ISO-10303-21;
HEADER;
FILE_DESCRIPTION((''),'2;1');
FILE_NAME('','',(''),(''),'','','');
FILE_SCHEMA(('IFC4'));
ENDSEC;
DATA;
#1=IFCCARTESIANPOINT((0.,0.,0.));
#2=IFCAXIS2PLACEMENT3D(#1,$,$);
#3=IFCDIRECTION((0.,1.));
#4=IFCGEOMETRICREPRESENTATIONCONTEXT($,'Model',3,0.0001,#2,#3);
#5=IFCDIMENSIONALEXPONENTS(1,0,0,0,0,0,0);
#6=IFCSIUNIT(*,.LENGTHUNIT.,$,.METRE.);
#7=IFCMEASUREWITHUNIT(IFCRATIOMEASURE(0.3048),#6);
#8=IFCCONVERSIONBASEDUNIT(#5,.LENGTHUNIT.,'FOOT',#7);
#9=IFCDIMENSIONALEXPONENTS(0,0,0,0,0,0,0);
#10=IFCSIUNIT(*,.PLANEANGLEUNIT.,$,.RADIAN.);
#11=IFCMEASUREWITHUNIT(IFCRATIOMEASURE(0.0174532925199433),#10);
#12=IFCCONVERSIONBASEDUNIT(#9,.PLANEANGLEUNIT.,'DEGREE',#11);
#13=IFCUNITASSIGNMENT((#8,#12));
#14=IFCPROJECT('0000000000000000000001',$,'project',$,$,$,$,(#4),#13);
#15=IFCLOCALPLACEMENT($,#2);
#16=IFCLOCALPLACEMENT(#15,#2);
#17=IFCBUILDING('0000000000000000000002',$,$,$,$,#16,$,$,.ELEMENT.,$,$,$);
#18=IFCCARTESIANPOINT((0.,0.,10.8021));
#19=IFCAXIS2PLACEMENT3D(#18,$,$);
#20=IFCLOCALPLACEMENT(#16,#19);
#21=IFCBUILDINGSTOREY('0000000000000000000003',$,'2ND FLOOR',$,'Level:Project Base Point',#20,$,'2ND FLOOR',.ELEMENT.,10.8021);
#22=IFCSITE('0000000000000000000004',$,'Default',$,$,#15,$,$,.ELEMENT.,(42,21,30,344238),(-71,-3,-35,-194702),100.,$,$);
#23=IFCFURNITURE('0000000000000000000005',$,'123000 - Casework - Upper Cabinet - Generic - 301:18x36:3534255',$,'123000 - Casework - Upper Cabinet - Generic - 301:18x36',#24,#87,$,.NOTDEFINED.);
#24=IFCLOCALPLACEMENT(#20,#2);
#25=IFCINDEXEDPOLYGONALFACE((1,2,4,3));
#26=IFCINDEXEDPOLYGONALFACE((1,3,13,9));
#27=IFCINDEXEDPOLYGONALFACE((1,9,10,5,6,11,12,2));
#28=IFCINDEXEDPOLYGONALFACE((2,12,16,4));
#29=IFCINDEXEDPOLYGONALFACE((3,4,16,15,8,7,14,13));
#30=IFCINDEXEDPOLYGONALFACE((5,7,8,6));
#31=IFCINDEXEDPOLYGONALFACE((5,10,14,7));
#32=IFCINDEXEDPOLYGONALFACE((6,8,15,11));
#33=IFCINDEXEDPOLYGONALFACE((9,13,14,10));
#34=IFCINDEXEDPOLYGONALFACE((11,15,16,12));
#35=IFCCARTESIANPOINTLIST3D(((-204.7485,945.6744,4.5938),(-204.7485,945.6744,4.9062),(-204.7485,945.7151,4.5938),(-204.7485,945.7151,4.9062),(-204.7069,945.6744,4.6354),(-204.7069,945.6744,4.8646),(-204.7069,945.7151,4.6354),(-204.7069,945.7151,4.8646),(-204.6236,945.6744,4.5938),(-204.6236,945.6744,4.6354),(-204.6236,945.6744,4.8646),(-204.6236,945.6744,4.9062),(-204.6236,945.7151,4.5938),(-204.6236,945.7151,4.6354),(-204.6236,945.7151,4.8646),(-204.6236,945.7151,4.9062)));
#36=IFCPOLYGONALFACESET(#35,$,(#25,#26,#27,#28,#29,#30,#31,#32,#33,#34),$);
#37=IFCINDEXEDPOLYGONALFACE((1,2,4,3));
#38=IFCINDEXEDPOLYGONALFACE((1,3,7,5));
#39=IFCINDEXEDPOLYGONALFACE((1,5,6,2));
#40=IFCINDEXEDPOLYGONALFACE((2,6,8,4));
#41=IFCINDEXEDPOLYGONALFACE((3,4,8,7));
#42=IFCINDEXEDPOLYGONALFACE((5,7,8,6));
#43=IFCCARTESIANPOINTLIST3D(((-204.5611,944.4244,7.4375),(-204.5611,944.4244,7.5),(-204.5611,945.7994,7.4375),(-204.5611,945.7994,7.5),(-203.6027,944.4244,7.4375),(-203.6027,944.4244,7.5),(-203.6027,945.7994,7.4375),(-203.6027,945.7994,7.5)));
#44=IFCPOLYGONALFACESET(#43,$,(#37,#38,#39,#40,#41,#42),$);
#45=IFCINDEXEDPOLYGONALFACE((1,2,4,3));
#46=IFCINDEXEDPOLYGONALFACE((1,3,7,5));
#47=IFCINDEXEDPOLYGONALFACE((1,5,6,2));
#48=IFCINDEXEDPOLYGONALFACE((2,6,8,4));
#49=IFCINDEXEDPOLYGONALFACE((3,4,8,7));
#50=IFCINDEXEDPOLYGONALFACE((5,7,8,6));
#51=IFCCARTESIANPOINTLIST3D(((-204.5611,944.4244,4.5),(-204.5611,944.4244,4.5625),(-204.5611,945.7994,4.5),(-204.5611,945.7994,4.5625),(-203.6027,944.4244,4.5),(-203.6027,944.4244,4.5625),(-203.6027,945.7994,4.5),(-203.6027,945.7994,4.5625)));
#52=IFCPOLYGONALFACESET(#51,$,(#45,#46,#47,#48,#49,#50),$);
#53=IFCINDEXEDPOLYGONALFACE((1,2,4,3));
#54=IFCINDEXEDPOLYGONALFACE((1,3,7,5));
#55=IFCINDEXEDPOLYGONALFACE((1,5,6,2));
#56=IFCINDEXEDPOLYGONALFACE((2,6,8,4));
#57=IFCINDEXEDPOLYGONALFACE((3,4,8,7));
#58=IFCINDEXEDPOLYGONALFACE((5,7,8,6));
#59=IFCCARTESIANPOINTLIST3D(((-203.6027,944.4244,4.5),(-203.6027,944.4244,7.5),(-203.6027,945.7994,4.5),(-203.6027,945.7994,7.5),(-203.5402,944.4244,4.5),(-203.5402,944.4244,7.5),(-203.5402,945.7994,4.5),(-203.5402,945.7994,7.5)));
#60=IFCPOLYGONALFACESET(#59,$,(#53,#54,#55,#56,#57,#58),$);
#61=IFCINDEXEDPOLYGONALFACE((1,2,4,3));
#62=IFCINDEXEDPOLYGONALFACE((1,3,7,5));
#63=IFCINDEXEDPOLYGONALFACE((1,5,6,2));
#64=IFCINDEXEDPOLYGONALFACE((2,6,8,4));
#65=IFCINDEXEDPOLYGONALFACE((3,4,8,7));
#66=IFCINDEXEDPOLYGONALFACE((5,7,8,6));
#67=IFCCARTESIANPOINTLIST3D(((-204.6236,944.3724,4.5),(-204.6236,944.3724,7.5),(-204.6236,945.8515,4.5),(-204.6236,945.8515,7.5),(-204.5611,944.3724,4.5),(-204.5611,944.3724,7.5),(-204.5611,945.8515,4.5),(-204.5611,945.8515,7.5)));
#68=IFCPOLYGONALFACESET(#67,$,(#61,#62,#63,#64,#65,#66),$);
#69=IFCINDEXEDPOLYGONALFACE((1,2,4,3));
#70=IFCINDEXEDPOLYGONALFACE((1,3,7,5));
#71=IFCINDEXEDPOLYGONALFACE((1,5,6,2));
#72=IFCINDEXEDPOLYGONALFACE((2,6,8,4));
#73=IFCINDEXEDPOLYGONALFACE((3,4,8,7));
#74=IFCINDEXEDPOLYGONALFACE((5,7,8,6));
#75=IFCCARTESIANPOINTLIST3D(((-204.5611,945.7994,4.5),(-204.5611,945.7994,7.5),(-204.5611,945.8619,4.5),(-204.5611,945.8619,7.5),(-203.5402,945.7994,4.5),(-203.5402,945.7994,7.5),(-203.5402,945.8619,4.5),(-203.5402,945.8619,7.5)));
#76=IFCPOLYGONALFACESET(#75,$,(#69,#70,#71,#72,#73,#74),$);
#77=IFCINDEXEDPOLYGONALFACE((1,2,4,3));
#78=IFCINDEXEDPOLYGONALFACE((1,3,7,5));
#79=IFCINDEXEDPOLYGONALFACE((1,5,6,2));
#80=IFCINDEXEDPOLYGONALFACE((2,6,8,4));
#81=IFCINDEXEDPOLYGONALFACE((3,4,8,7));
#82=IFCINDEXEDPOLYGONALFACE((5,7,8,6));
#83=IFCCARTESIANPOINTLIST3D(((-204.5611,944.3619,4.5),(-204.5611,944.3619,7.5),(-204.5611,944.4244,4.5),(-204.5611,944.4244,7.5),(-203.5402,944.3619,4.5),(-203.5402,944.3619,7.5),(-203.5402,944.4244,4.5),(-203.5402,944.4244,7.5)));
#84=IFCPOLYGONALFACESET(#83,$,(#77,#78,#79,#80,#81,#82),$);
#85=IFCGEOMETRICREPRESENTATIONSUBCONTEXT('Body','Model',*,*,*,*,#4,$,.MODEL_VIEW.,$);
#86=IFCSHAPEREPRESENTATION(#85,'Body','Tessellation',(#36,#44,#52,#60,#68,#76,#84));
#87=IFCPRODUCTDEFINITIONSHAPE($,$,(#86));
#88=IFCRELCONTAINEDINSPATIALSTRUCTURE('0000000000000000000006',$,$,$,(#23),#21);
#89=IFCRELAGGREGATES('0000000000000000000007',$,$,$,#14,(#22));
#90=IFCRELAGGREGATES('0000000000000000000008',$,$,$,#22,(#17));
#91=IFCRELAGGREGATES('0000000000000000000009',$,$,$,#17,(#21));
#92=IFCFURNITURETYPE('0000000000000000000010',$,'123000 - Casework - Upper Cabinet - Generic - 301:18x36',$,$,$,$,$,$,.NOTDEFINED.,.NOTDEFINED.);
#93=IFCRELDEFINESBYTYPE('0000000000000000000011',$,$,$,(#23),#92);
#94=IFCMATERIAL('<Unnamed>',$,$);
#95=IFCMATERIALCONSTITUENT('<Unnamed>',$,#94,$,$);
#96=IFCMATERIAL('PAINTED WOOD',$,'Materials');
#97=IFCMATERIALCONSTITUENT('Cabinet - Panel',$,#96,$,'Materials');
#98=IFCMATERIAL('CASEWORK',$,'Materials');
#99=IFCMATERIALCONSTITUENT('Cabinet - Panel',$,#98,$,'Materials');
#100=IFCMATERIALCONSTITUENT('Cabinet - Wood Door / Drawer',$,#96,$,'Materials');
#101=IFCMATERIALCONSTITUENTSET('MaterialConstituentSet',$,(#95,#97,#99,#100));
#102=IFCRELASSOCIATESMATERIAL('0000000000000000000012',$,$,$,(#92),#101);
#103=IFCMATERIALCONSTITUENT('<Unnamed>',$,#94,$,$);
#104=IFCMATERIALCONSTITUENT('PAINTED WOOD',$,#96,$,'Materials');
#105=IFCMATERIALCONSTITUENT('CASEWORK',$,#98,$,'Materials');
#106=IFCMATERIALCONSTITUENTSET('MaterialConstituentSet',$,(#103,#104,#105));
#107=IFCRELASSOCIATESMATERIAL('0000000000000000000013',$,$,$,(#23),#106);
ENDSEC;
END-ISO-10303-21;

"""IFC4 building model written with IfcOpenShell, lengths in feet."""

from ifc_helpers import new_model, entity, si_unit, converted_unit, direction, frame, frame_2d, origin, origin_2d_with_axis, place, context, subcontext, project, spatial, polyline, rectangle, outline, extrude, source, transform, mapped, material, constituent, constituent_set, type_object, type_shapes, element, save


model = new_model("IFC4")

# Units and contexts
model_context = context("Model", 3, precision=0.0001, world=origin(), true_north=direction((0.0, 1.0)))
body_context = subcontext(model_context, "Body", "Model", "MODEL_VIEW")
ifc_project = project(units=[converted_unit("LENGTHUNIT", "FOOT", entity("IfcRatioMeasure", 0.3048), si_unit("LENGTHUNIT", "METRE"), dimensions=[1, 0, 0, 0, 0, 0, 0]), converted_unit("PLANEANGLEUNIT", "DEGREE", entity("IfcRatioMeasure", 0.0174532925199433), si_unit("PLANEANGLEUNIT", "RADIAN"), dimensions=[0, 0, 0, 0, 0, 0, 0])], contexts=[model_context])

# Site, building, storey
site_placement = place(None, origin())
site = spatial("IfcSite", under=ifc_project, at=site_placement, Name="Default", CompositionType="ELEMENT", RefLatitude=(42, 21, 30, 344238), RefLongitude=(-71, -3, -35, -194702), RefElevation=100.0)
building_placement = place(site_placement, origin())
building = spatial("IfcBuilding", under=site, at=building_placement, CompositionType="ELEMENT")
storey_placement = place(building_placement, frame((0.0, 0.0, 10.8021)))
storey = spatial("IfcBuildingStorey", under=building, at=storey_placement, Name="2ND FLOOR", ObjectType="Level:Project Base Point", LongName="2ND FLOOR", CompositionType="ELEMENT", Elevation=10.8021)

# Furniture
ifc_material_1 = material(Name="<Unnamed>")
ifc_material_2 = material(Name="CASEWORK", Category="Materials")
ifc_material_3 = material(Name="PAINTED WOOD", Category="Materials")
ifc_constituent_1 = constituent(ifc_material_1, Name="<Unnamed>")
ifc_constituent_2 = constituent(ifc_material_3, Name="PAINTED WOOD", Category="Materials")
ifc_constituent_3 = constituent(ifc_material_2, Name="CASEWORK", Category="Materials")
ifc_constituent_set_1 = constituent_set(constituents=[ifc_constituent_1, ifc_constituent_2, ifc_constituent_3], Name="MaterialConstituentSet")
ifc_constituent_4 = constituent(ifc_material_1, Name="<Unnamed>")
ifc_constituent_5 = constituent(ifc_material_3, Name="Cabinet - Panel", Category="Materials")
ifc_constituent_6 = constituent(ifc_material_2, Name="Cabinet - Panel", Category="Materials")
ifc_constituent_7 = constituent(ifc_material_3, Name="Cabinet - Wood Door / Drawer", Category="Materials")
ifc_constituent_set_2 = constituent_set(constituents=[ifc_constituent_4, ifc_constituent_5, ifc_constituent_6, ifc_constituent_7], Name="MaterialConstituentSet")
furniture_type_1 = type_object("IfcFurnitureType", Name="123000 - Casework - Upper Cabinet - Generic - 301:18x36", AssemblyPlace="NOTDEFINED", PredefinedType="NOTDEFINED", material=ifc_constituent_set_2)
shared_shape_1 = source(origin(), body_context, "Body", "SweptSolid", [
    extrude(outline(polyline([(0.1146, -0.0521), (0.1562, -0.0521), (0.1562, 0.0729), (-0.1562, 0.0729), (-0.1562, -0.0521), (-0.1146, -0.0521), (-0.1146, 0.0313), (0.1146, 0.0313), (0.1146, -0.0521)])), frame((0.1468, 0.0729, 0.25), z_axis=(1.0, 0.0, 0.0), x_axis=(0.0, 0.0, 1.0)), (0.0, 0.0, 1.0), 0.0407),
    extrude(rectangle(XDim=1.375, YDim=0.9583, at=frame_2d((0.0, 0.0), x_axis=(1.0, 0.0))), frame((0.75, 0.6666, 2.9375), z_axis=(0.0, 0.0, 1.0), x_axis=(-1.0, 0.0, 0.0)), (0.0, 0.0, 1.0), 0.0625),
    extrude(rectangle(XDim=1.375, YDim=0.9583, at=frame_2d((0.0, 0.0), x_axis=(1.0, 0.0))), frame((0.75, 0.6666, 0.0), z_axis=(0.0, 0.0, 1.0), x_axis=(-1.0, 0.0, 0.0)), (0.0, 0.0, 1.0), 0.0625),
    extrude(rectangle(XDim=0.0625, YDim=1.375, at=origin_2d_with_axis()), frame((0.75, 1.177, 0.0), z_axis=(0.0, 0.0, 1.0), x_axis=(0.0, 1.0, 0.0)), (0.0, 0.0, 1.0), 3.0),
    extrude(rectangle(XDim=0.0625, YDim=1.4792, at=origin_2d_with_axis()), frame((0.75, 0.1562, 0.0), z_axis=(0.0, 0.0, 1.0), x_axis=(0.0, -1.0, 0.0)), (0.0, 0.0, 1.0), 3.0),
    extrude(rectangle(XDim=0.0625, YDim=1.0208, at=origin_2d_with_axis()), frame((0.0312, 0.6979, 0.0), z_axis=(0.0, 0.0, 1.0), x_axis=(-1.0, 0.0, 0.0)), (0.0, 0.0, 1.0), 3.0),
    extrude(rectangle(XDim=0.0625, YDim=1.0208, at=origin_2d_with_axis()), frame((1.4688, 0.6979, 0.0), z_axis=(0.0, 0.0, 1.0), x_axis=(-1.0, 0.0, 0.0)), (0.0, 0.0, 1.0), 3.0),
])
type_shapes(furniture_type_1, [shared_shape_1])
furniture_1_placement = place(storey_placement, frame((-204.7485, 945.8619, 4.5), z_axis=(0.0, 0.0, 1.0), x_axis=(0.0, -1.0, 0.0)))
element("IfcFurniture", 1, at=furniture_1_placement, inside=storey, type_object=furniture_type_1, material=ifc_constituent_set_1, Name="123000 - Casework - Upper Cabinet - Generic - 301:18x36:3534255", ObjectType="123000 - Casework - Upper Cabinet - Generic - 301:18x36", PredefinedType="NOTDEFINED", context=body_context, shape_type="MappedRepresentation", body=[
    mapped(shared_shape_1, transform((0.0, 0.0, 0.0), scale=1.0)),
])

save(model, "model.ifc")
